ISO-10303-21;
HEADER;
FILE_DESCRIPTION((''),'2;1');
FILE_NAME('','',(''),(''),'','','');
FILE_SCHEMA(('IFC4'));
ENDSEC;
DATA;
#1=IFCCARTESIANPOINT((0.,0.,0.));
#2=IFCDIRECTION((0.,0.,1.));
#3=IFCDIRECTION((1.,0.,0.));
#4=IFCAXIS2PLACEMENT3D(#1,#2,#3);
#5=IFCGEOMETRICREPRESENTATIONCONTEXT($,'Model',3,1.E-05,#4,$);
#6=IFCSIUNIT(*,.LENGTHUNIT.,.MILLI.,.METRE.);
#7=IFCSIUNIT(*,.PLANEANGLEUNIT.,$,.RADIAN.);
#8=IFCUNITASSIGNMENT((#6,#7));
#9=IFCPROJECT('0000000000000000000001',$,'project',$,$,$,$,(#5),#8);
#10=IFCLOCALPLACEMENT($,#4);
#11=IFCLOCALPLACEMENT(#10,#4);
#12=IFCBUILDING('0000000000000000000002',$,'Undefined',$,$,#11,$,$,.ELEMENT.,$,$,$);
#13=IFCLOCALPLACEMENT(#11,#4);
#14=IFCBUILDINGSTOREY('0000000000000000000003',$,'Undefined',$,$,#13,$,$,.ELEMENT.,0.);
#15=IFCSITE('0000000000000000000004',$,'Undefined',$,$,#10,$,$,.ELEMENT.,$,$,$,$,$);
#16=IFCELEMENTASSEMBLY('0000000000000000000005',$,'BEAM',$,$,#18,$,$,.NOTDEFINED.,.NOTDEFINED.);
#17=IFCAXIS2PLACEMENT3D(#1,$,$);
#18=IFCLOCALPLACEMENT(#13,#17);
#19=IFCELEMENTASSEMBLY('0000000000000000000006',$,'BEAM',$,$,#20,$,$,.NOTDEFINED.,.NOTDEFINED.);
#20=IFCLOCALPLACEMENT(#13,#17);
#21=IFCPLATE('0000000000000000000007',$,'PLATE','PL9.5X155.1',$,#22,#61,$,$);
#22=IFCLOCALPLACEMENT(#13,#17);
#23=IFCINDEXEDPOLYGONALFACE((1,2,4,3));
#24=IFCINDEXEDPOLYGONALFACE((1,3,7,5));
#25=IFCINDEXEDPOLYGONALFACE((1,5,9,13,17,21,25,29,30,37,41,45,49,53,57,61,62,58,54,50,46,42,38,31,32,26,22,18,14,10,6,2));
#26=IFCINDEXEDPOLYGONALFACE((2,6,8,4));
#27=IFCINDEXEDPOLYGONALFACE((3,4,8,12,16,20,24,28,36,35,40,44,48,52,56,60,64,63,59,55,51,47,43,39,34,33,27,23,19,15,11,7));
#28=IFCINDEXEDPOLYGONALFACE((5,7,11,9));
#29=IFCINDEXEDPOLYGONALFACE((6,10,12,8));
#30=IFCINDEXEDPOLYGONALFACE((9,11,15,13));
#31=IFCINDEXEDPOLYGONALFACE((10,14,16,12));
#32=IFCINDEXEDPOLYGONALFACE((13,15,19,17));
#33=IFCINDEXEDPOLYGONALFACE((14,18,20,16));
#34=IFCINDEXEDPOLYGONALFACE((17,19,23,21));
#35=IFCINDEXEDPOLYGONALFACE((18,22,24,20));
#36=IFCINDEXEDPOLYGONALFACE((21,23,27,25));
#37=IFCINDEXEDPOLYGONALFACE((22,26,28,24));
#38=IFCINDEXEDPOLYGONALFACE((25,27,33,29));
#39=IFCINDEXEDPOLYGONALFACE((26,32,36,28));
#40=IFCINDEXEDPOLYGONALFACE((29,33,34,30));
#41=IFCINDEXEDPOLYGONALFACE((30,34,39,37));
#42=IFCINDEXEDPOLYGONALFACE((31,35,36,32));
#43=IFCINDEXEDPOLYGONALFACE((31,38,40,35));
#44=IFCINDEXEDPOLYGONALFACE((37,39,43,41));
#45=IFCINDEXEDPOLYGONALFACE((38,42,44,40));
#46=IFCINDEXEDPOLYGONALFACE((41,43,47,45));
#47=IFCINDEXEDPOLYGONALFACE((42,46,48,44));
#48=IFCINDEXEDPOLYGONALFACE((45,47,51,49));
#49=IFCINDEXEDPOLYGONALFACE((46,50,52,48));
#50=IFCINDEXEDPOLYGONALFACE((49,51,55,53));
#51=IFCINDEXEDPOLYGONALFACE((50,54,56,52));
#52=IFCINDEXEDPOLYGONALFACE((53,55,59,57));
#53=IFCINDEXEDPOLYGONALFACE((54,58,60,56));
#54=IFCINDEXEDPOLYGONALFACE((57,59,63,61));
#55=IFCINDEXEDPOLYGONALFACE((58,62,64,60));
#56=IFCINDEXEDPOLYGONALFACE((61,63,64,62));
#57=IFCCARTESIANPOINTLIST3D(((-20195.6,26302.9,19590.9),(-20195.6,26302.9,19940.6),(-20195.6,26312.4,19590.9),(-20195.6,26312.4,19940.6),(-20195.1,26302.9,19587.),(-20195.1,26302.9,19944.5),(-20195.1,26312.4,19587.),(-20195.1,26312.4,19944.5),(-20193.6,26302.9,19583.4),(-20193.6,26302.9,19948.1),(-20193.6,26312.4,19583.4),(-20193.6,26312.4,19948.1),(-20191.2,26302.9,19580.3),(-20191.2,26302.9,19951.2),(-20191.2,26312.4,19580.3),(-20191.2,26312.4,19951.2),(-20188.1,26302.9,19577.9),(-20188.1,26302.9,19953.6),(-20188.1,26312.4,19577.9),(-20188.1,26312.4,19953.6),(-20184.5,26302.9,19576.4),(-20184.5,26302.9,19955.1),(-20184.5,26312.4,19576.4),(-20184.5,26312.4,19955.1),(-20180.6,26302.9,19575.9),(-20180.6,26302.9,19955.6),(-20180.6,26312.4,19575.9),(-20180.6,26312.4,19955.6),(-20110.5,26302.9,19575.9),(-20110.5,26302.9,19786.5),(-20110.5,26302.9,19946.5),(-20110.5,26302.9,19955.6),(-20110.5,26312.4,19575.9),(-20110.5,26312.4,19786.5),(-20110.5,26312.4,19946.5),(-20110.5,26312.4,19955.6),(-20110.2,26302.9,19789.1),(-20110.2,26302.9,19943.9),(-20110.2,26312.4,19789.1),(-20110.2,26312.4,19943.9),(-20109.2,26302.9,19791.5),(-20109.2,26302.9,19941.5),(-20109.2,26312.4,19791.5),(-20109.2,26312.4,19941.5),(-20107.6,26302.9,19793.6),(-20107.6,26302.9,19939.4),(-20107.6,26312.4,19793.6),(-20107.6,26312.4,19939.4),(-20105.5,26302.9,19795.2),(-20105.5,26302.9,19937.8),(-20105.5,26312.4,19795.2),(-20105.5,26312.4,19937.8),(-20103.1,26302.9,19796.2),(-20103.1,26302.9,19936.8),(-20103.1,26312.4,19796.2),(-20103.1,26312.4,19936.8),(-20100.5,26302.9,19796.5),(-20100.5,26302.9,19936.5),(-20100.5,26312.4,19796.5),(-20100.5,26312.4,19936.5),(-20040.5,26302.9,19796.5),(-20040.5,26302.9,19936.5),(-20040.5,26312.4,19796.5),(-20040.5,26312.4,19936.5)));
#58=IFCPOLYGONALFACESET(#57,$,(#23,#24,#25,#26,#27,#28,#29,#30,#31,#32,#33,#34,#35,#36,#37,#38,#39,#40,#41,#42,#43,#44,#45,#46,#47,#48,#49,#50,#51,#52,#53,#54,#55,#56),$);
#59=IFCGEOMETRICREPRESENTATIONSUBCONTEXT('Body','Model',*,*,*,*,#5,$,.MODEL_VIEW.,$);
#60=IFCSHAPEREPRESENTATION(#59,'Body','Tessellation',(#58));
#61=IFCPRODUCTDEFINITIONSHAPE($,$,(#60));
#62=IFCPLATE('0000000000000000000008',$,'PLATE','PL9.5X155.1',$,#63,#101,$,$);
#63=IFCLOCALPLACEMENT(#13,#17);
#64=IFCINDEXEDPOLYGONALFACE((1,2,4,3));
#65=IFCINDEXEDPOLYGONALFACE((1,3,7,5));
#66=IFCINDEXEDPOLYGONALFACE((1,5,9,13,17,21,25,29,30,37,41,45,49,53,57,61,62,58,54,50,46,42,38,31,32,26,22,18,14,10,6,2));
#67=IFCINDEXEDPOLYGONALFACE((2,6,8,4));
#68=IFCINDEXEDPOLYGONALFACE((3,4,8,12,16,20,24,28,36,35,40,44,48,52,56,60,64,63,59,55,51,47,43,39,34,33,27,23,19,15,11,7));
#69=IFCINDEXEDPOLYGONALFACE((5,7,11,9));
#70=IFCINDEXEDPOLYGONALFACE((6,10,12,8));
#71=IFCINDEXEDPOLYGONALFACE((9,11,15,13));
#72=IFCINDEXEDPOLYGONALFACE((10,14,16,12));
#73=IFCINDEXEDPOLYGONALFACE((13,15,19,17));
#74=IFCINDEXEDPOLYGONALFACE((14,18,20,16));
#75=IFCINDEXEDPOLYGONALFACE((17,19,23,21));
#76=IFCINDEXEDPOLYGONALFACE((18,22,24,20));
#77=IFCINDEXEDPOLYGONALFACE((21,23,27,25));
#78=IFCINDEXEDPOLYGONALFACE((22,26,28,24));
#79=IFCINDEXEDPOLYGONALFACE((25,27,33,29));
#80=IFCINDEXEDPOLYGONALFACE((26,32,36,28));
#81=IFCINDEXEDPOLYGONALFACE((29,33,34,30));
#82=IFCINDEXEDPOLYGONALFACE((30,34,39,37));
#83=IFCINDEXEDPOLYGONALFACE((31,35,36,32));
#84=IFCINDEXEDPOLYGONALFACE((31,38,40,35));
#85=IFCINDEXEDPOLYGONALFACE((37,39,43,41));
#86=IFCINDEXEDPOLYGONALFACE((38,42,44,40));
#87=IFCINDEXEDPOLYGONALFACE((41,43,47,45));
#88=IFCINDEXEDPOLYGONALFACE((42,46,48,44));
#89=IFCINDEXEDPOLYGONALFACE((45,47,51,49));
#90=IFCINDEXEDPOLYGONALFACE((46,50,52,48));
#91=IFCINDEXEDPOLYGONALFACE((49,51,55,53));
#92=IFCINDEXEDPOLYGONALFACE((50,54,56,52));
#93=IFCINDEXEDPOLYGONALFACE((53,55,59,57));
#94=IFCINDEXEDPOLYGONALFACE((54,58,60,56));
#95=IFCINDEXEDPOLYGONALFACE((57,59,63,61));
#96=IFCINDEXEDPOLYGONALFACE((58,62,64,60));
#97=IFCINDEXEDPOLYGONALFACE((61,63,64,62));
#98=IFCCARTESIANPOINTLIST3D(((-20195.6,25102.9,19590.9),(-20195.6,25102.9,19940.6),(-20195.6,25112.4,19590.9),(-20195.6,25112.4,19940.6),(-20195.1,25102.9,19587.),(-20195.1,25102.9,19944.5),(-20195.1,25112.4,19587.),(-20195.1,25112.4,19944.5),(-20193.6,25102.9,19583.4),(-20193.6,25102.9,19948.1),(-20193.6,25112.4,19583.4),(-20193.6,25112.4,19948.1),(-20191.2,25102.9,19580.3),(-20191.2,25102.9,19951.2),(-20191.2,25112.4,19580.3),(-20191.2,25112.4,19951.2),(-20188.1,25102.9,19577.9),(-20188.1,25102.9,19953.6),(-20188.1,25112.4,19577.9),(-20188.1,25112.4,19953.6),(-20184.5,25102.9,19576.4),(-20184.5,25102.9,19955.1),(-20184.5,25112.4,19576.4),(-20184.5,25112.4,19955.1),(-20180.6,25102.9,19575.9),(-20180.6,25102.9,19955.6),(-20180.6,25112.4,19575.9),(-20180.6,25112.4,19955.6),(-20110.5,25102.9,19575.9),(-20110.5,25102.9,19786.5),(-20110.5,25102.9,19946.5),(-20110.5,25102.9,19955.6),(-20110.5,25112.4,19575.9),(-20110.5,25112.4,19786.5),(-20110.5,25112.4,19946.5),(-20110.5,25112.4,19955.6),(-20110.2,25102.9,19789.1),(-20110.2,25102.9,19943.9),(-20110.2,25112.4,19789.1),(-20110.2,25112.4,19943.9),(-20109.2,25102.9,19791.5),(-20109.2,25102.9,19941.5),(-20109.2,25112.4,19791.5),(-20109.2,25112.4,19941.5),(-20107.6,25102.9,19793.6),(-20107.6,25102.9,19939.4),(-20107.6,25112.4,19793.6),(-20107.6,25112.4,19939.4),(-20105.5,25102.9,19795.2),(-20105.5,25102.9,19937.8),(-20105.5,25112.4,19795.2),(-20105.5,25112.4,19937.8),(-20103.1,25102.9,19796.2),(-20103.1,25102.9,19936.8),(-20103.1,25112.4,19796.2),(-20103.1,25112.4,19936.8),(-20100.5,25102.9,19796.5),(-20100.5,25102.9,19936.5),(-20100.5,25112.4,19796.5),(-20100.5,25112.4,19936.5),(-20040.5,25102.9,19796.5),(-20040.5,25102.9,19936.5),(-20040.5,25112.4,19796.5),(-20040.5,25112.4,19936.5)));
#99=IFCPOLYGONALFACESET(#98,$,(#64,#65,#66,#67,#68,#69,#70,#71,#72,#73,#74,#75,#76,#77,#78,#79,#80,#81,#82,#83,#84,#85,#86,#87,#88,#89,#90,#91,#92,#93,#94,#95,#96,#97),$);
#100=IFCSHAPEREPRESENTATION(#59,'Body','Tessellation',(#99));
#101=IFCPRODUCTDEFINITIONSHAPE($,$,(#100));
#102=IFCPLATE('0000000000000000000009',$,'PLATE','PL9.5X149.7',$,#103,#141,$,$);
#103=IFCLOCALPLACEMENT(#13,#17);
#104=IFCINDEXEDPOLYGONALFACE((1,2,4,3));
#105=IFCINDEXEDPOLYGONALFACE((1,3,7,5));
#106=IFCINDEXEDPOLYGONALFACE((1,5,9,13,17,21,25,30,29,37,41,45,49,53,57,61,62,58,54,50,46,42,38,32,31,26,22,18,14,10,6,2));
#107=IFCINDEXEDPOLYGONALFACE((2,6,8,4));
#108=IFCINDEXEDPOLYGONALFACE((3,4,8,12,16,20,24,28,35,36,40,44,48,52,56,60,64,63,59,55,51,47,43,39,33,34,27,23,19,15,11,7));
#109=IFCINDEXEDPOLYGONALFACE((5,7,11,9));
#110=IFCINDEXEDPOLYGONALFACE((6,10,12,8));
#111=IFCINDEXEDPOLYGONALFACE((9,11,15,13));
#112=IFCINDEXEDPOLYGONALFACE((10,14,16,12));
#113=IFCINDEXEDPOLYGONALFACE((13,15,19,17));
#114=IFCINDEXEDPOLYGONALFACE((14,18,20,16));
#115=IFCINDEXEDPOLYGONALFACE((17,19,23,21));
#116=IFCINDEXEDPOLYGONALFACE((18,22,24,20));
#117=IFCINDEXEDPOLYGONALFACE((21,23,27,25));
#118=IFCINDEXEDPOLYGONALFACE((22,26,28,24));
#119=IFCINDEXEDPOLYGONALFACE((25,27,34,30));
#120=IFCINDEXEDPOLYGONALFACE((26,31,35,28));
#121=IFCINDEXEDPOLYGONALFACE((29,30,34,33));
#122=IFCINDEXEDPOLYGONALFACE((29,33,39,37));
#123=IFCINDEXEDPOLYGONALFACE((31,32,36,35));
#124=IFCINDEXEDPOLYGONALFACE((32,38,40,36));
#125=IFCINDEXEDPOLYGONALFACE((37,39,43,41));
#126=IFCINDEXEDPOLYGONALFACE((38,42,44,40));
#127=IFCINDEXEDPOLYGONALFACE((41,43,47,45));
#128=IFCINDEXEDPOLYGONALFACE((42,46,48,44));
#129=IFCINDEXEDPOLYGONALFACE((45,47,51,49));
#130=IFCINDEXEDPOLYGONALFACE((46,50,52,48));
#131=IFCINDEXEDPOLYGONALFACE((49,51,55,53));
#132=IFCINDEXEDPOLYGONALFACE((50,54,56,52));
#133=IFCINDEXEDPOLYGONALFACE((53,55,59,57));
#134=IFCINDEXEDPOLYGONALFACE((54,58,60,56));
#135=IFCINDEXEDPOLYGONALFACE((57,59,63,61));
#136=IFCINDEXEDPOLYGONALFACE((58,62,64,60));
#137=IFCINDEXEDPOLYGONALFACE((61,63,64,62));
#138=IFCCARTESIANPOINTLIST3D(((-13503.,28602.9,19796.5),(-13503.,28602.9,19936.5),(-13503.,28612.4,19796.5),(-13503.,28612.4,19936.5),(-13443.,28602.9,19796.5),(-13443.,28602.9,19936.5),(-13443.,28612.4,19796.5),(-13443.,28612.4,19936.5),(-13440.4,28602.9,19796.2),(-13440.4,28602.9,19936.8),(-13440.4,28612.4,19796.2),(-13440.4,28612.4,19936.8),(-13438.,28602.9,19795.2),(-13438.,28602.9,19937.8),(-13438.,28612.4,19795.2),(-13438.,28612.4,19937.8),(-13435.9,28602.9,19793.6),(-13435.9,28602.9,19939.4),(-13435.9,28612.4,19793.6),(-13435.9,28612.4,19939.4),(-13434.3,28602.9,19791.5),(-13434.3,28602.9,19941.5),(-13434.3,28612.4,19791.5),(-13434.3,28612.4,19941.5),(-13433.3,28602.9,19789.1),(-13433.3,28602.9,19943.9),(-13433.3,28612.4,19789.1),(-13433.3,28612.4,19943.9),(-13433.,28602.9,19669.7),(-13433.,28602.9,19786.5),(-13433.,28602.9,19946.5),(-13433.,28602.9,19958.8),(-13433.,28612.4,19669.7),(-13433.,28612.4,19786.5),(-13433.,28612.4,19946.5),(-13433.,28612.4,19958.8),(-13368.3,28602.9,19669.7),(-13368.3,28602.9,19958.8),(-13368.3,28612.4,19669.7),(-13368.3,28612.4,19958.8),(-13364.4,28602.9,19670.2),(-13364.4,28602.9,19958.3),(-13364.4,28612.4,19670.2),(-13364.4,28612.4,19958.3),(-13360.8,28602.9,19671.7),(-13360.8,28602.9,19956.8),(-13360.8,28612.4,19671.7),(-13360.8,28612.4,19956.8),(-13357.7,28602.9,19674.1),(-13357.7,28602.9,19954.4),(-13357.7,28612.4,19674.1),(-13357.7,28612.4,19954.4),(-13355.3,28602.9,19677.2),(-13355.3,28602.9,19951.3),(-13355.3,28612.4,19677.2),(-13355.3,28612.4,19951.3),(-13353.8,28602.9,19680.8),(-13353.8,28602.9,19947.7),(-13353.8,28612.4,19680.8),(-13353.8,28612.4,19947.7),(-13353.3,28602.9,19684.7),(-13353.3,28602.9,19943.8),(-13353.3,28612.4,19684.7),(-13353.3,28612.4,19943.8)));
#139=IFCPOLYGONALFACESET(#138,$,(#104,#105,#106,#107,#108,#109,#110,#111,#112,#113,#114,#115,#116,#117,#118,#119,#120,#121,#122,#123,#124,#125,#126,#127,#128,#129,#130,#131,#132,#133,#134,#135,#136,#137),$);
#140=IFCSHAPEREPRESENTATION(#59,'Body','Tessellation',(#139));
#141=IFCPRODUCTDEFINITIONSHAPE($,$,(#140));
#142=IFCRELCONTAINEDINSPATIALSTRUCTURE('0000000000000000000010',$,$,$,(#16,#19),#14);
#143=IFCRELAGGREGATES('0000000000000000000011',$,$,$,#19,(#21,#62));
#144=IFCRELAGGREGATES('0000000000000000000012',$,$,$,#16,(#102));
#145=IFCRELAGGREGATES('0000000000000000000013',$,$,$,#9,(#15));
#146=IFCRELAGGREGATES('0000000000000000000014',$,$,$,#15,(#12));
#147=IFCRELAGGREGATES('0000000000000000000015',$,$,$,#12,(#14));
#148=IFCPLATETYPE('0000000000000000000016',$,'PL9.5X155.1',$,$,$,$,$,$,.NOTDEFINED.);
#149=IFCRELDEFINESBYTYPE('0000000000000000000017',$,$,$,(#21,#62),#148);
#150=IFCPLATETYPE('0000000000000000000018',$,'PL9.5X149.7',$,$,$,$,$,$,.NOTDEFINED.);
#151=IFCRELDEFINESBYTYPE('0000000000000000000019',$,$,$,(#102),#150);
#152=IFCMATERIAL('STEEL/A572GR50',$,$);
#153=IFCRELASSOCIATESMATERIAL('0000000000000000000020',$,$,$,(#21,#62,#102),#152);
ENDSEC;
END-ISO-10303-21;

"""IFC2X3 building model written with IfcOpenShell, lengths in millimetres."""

from ifc_helpers import new_model, si_unit, frame, frame_2d, origin_with_axes, place, context, subcontext, project, spatial, polyline, circle_curve, parameter, trimmed, segment, composite_curve, outline, extrude, material, type_object, element, aggregate, save


model = new_model("IFC2X3")

# Units and contexts
model_context = context("Model", 3, precision=1e-05, world=origin_with_axes())
body_context = subcontext(model_context, "Body", "Model", "MODEL_VIEW")
ifc_project = project(units=[si_unit("LENGTHUNIT", "METRE", prefix="MILLI"), si_unit("PLANEANGLEUNIT", "RADIAN")], contexts=[model_context])

# Site, building, storey
site_placement = place(None, origin_with_axes())
site = spatial("IfcSite", under=ifc_project, at=site_placement, Name="Undefined", CompositionType="ELEMENT")
building_placement = place(site_placement, origin_with_axes())
building = spatial("IfcBuilding", under=site, at=building_placement, Name="Undefined", CompositionType="ELEMENT")
storey_placement = place(building_placement, origin_with_axes())
storey = spatial("IfcBuildingStorey", under=building, at=storey_placement, Name="Undefined", CompositionType="ELEMENT", Elevation=0.0)

# Shared definitions
ifc_material_1 = material(Name="STEEL/A572GR50")

# Element assembly
assembly_1_placement = place(storey_placement, origin_with_axes())
assembly_1 = element("IfcElementAssembly", 1, at=assembly_1_placement, inside=storey, Name="BEAM", AssemblyPlace="NOTDEFINED", PredefinedType="NOTDEFINED")

# Element assembly, plates
assembly_2_placement = place(storey_placement, origin_with_axes())
assembly_2 = element("IfcElementAssembly", 2, at=assembly_2_placement, inside=storey, Name="BEAM", AssemblyPlace="NOTDEFINED", PredefinedType="NOTDEFINED")
plate_type_1 = type_object("IfcPlateType", Name="PL9.5X155.1", PredefinedType="NOTDEFINED")
plate_1_placement = place(assembly_2_placement, frame((-20195.6, 26307.7, 19955.6), z_axis=(0.0, -1.0, 0.0), x_axis=(0.0, 0.0, -1.0)))
plate_1 = element("IfcPlate", 3, at=plate_1_placement, type_object=plate_type_1, material=ifc_material_1, Name="PLATE", Description="PL9.5X155.1", context=body_context, shape_type="SweptSolid", body=[
    extrude(outline(composite_curve([segment(trimmed(circle_curve(frame_2d((15.0, 15.0), x_axis=(-1.0, 0.0)), 15.0), [parameter(0.0)], [parameter(1.570796)], True, "PARAMETER"), True, "CONTINUOUS"), segment(polyline([(15.0, 0.0), (364.7, 0.0)]), True, "CONTINUOUS"), segment(trimmed(circle_curve(frame_2d((364.7, 15.0), x_axis=(0.0, -1.0)), 15.0), [parameter(0.0)], [parameter(1.570796)], True, "PARAMETER"), True, "CONTINUOUS"), segment(polyline([(379.7, 15.0), (379.7, 85.1), (169.1, 85.1)]), True, "CONTINUOUS"), segment(trimmed(circle_curve(frame_2d((169.1, 95.1), x_axis=(0.0, -1.0)), 10.0), [parameter(0.0)], [parameter(4.712389)], False, "PARAMETER"), True, "CONTINUOUS"), segment(polyline([(159.1, 95.1), (159.1, 155.1), (19.1, 155.1), (19.1, 95.1)]), True, "CONTINUOUS"), segment(trimmed(circle_curve(frame_2d((9.1, 95.1), x_axis=(1.0, 0.0)), 10.0), [parameter(0.0)], [parameter(4.712389)], False, "PARAMETER"), True, "CONTINUOUS"), segment(polyline([(9.1, 85.1), (0.0, 85.1), (0.0, 15.0)]), True, "CONTINUOUS")], self_intersect=True)), frame((0.0, 0.0, -4.8), z_axis=(0.0, 0.0, 1.0), x_axis=(1.0, 0.0, 0.0)), (0.0, 0.0, 1.0), 9.5),
])
plate_2_placement = place(assembly_2_placement, frame((-20195.6, 25107.7, 19955.6), z_axis=(0.0, -1.0, 0.0), x_axis=(0.0, 0.0, -1.0)))
plate_2 = element("IfcPlate", 4, at=plate_2_placement, type_object=plate_type_1, material=ifc_material_1, Name="PLATE", Description="PL9.5X155.1", context=body_context, shape_type="SweptSolid", body=[
    extrude(outline(composite_curve([segment(trimmed(circle_curve(frame_2d((15.0, 15.0), x_axis=(-1.0, 0.0)), 15.0), [parameter(0.0)], [parameter(1.570796)], True, "PARAMETER"), True, "CONTINUOUS"), segment(polyline([(15.0, 0.0), (364.7, 0.0)]), True, "CONTINUOUS"), segment(trimmed(circle_curve(frame_2d((364.7, 15.0), x_axis=(0.0, -1.0)), 15.0), [parameter(0.0)], [parameter(1.570796)], True, "PARAMETER"), True, "CONTINUOUS"), segment(polyline([(379.7, 15.0), (379.7, 85.1), (169.1, 85.1)]), True, "CONTINUOUS"), segment(trimmed(circle_curve(frame_2d((169.1, 95.1), x_axis=(0.0, -1.0)), 10.0), [parameter(0.0)], [parameter(4.712389)], False, "PARAMETER"), True, "CONTINUOUS"), segment(polyline([(159.1, 95.1), (159.1, 155.1), (19.1, 155.1), (19.1, 95.1)]), True, "CONTINUOUS"), segment(trimmed(circle_curve(frame_2d((9.1, 95.1), x_axis=(1.0, 0.0)), 10.0), [parameter(0.0)], [parameter(4.712389)], False, "PARAMETER"), True, "CONTINUOUS"), segment(polyline([(9.1, 85.1), (0.0, 85.1), (0.0, 15.0)]), True, "CONTINUOUS")], self_intersect=True)), frame((0.0, 0.0, -4.8), z_axis=(0.0, 0.0, 1.0), x_axis=(1.0, 0.0, 0.0)), (0.0, 0.0, 1.0), 9.5),
])
aggregate(assembly_2, [plate_1, plate_2])

# Plate
plate_type_2 = type_object("IfcPlateType", Name="PL9.5X149.7", PredefinedType="NOTDEFINED")
plate_3_placement = place(assembly_1_placement, frame((-13353.3, 28607.7, 19958.8), z_axis=(0.0, 1.0, 0.0), x_axis=(0.0, 0.0, -1.0)))
plate_3 = element("IfcPlate", 5, at=plate_3_placement, type_object=plate_type_2, material=ifc_material_1, Name="PLATE", Description="PL9.5X149.7", context=body_context, shape_type="SweptSolid", body=[
    extrude(outline(composite_curve([segment(trimmed(circle_curve(frame_2d((15.0, 15.0), x_axis=(-1.0, 0.0)), 15.0), [parameter(0.0)], [parameter(1.570796)], True, "PARAMETER"), True, "CONTINUOUS"), segment(polyline([(15.0, 0.0), (274.1, 0.0)]), True, "CONTINUOUS"), segment(trimmed(circle_curve(frame_2d((274.1, 15.0), x_axis=(0.0, -1.0)), 15.0), [parameter(0.0)], [parameter(1.570796)], True, "PARAMETER"), True, "CONTINUOUS"), segment(polyline([(289.1, 15.0), (289.1, 79.7), (172.3, 79.7)]), True, "CONTINUOUS"), segment(trimmed(circle_curve(frame_2d((172.3, 89.7), x_axis=(0.0, -1.0)), 10.0), [parameter(0.0)], [parameter(4.712389)], False, "PARAMETER"), True, "CONTINUOUS"), segment(polyline([(162.3, 89.7), (162.3, 149.7), (22.3, 149.7), (22.3, 89.7)]), True, "CONTINUOUS"), segment(trimmed(circle_curve(frame_2d((12.3, 89.7), x_axis=(1.0, 0.0)), 10.0), [parameter(0.0)], [parameter(4.712389)], False, "PARAMETER"), True, "CONTINUOUS"), segment(polyline([(12.3, 79.7), (0.0, 79.7), (0.0, 15.0)]), True, "CONTINUOUS")], self_intersect=True)), frame((0.0, 0.0, -4.8), z_axis=(0.0, 0.0, 1.0), x_axis=(1.0, 0.0, 0.0)), (0.0, 0.0, 1.0), 9.5),
])

aggregate(assembly_1, [plate_3])

save(model, "model.ifc")
